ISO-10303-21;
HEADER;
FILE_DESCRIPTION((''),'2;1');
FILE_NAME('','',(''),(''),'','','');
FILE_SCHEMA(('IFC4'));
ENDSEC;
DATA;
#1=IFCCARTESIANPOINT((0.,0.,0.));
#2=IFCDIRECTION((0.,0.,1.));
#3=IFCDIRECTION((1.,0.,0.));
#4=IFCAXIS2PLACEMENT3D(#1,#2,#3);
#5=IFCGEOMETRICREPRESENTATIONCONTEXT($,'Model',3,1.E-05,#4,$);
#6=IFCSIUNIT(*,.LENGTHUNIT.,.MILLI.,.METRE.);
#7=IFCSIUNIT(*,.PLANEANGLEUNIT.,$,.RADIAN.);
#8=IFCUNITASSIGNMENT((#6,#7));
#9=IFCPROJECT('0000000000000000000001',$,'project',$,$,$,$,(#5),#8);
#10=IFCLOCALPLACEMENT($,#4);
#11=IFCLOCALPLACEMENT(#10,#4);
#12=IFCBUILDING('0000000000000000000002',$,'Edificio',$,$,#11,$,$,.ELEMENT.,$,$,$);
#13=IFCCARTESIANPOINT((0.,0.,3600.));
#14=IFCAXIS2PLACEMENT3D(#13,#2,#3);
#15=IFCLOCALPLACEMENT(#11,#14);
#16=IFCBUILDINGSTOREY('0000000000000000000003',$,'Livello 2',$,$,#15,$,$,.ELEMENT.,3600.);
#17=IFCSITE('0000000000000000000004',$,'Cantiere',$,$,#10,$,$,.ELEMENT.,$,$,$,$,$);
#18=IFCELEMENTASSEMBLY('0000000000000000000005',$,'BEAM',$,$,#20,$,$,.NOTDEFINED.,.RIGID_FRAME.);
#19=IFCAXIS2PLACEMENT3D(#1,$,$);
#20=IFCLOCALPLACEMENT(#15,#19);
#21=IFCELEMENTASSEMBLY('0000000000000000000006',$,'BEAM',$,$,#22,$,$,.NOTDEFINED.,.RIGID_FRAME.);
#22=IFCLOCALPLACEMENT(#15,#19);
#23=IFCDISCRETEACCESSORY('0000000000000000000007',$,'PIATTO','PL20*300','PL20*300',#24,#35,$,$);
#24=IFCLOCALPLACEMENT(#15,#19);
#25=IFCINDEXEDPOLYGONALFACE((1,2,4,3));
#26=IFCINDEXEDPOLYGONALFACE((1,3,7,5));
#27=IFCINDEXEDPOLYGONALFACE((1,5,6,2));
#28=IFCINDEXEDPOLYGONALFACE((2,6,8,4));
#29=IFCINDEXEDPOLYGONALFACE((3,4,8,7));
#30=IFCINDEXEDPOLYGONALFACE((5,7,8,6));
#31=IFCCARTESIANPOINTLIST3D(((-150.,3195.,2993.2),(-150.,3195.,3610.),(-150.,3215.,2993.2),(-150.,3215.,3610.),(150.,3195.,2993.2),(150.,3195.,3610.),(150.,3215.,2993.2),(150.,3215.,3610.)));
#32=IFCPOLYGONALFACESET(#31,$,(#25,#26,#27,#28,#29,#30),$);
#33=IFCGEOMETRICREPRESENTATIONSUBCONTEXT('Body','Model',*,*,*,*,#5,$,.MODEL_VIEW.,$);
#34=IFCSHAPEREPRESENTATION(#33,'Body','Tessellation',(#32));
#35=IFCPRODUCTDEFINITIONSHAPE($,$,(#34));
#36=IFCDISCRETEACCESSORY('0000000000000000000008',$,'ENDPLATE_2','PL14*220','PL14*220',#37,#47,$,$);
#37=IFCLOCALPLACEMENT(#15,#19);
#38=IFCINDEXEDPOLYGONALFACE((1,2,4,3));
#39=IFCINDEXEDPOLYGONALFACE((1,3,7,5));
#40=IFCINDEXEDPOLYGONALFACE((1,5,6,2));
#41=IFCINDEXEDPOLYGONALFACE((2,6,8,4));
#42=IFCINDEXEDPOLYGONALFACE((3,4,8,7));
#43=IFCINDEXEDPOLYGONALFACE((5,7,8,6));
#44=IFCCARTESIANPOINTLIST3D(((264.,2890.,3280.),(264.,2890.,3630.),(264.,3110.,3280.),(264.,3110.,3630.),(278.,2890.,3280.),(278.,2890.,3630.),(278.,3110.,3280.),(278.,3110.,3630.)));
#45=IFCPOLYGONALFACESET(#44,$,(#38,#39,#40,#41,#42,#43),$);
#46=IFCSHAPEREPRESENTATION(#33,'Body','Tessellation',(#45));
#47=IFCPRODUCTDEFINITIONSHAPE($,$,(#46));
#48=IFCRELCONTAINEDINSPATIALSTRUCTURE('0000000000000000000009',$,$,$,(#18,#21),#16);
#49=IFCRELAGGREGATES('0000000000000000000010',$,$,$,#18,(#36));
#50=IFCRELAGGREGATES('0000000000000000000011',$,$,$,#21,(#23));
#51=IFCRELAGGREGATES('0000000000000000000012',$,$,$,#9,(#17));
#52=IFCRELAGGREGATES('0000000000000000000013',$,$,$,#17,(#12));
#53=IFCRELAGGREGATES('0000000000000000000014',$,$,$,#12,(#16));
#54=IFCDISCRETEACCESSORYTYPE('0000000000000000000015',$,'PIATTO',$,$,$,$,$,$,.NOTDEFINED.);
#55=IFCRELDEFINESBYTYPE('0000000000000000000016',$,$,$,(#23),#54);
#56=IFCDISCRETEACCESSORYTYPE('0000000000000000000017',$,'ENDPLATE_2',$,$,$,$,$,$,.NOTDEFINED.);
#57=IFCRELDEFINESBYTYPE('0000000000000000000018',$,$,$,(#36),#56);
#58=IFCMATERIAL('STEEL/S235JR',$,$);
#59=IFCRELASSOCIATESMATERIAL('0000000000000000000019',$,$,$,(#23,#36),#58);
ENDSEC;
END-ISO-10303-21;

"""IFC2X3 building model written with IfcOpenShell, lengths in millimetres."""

from ifc_helpers import new_model, si_unit, frame, origin_with_axes, place, context, subcontext, project, spatial, polyline, outline, extrude, material, type_object, element, aggregate, save


model = new_model("IFC2X3")

# Units and contexts
model_context = context("Model", 3, precision=1e-05, world=origin_with_axes())
body_context = subcontext(model_context, "Body", "Model", "MODEL_VIEW")
ifc_project = project(units=[si_unit("LENGTHUNIT", "METRE", prefix="MILLI"), si_unit("PLANEANGLEUNIT", "RADIAN")], contexts=[model_context])

# Site, building, storey
site_placement = place(None, origin_with_axes())
site = spatial("IfcSite", under=ifc_project, at=site_placement, Name="Cantiere", CompositionType="ELEMENT")
building_placement = place(site_placement, origin_with_axes())
building = spatial("IfcBuilding", under=site, at=building_placement, Name="Edificio", CompositionType="ELEMENT")
storey_placement = place(building_placement, frame((0.0, 0.0, 3600.0), z_axis=(0.0, 0.0, 1.0), x_axis=(1.0, 0.0, 0.0)))
storey = spatial("IfcBuildingStorey", under=building, at=storey_placement, Name="Livello 2", CompositionType="ELEMENT", Elevation=3600.0)

# Element assembly
assembly_1_placement = place(storey_placement, origin_with_axes())
assembly_1 = element("IfcElementAssembly", 1, at=assembly_1_placement, inside=storey, Name="BEAM", AssemblyPlace="NOTDEFINED", PredefinedType="RIGID_FRAME")
ifc_material_1 = material(Name="STEEL/S235JR")

# Shared definitions
discrete_accessory_type_1 = type_object("IfcDiscreteAccessoryType", Name="PIATTO")

# Element assembly
assembly_2_placement = place(storey_placement, origin_with_axes())
assembly_2 = element("IfcElementAssembly", 2, at=assembly_2_placement, inside=storey, Name="BEAM", AssemblyPlace="NOTDEFINED", PredefinedType="RIGID_FRAME")

# Discrete accessory
discrete_accessory_1_placement = place(assembly_2_placement, frame((0.0, 3205.0, 2993.2), z_axis=(0.0, 1.0, 0.0), x_axis=(0.0, 0.0, 1.0)))
discrete_accessory_1 = element("IfcDiscreteAccessory", 3, at=discrete_accessory_1_placement, type_object=discrete_accessory_type_1, material=ifc_material_1, Name="PIATTO", Description="PL20*300", ObjectType="PL20*300", context=body_context, shape_type="SweptSolid", body=[
    extrude(outline(polyline([(0.0, -150.0), (0.0, 150.0), (616.8, 150.0), (616.8, -150.0), (0.0, -150.0)])), frame((0.0, 0.0, -10.0), z_axis=(0.0, 0.0, 1.0), x_axis=(1.0, 0.0, 0.0)), (0.0, 0.0, 1.0), 20.0),
])

# Discrete accessory
discrete_accessory_type_2 = type_object("IfcDiscreteAccessoryType", Name="ENDPLATE_2")
discrete_accessory_2_placement = place(assembly_1_placement, frame((271.0, 3110.0, 3280.0), z_axis=(1.0, 0.0, 0.0), x_axis=(0.0, 0.0, 1.0)))
discrete_accessory_2 = element("IfcDiscreteAccessory", 4, at=discrete_accessory_2_placement, type_object=discrete_accessory_type_2, material=ifc_material_1, Name="ENDPLATE_2", Description="PL14*220", ObjectType="PL14*220", context=body_context, shape_type="SweptSolid", body=[
    extrude(outline(polyline([(0.0, 0.0), (350.0, 0.0), (350.0, 220.0), (0.0, 220.0), (0.0, 0.0)])), frame((0.0, 0.0, -7.0), z_axis=(0.0, 0.0, 1.0), x_axis=(1.0, 0.0, 0.0)), (0.0, 0.0, 1.0), 14.0),
])
aggregate(assembly_1, [discrete_accessory_2])

aggregate(assembly_2, [discrete_accessory_1])

save(model, "model.ifc")
